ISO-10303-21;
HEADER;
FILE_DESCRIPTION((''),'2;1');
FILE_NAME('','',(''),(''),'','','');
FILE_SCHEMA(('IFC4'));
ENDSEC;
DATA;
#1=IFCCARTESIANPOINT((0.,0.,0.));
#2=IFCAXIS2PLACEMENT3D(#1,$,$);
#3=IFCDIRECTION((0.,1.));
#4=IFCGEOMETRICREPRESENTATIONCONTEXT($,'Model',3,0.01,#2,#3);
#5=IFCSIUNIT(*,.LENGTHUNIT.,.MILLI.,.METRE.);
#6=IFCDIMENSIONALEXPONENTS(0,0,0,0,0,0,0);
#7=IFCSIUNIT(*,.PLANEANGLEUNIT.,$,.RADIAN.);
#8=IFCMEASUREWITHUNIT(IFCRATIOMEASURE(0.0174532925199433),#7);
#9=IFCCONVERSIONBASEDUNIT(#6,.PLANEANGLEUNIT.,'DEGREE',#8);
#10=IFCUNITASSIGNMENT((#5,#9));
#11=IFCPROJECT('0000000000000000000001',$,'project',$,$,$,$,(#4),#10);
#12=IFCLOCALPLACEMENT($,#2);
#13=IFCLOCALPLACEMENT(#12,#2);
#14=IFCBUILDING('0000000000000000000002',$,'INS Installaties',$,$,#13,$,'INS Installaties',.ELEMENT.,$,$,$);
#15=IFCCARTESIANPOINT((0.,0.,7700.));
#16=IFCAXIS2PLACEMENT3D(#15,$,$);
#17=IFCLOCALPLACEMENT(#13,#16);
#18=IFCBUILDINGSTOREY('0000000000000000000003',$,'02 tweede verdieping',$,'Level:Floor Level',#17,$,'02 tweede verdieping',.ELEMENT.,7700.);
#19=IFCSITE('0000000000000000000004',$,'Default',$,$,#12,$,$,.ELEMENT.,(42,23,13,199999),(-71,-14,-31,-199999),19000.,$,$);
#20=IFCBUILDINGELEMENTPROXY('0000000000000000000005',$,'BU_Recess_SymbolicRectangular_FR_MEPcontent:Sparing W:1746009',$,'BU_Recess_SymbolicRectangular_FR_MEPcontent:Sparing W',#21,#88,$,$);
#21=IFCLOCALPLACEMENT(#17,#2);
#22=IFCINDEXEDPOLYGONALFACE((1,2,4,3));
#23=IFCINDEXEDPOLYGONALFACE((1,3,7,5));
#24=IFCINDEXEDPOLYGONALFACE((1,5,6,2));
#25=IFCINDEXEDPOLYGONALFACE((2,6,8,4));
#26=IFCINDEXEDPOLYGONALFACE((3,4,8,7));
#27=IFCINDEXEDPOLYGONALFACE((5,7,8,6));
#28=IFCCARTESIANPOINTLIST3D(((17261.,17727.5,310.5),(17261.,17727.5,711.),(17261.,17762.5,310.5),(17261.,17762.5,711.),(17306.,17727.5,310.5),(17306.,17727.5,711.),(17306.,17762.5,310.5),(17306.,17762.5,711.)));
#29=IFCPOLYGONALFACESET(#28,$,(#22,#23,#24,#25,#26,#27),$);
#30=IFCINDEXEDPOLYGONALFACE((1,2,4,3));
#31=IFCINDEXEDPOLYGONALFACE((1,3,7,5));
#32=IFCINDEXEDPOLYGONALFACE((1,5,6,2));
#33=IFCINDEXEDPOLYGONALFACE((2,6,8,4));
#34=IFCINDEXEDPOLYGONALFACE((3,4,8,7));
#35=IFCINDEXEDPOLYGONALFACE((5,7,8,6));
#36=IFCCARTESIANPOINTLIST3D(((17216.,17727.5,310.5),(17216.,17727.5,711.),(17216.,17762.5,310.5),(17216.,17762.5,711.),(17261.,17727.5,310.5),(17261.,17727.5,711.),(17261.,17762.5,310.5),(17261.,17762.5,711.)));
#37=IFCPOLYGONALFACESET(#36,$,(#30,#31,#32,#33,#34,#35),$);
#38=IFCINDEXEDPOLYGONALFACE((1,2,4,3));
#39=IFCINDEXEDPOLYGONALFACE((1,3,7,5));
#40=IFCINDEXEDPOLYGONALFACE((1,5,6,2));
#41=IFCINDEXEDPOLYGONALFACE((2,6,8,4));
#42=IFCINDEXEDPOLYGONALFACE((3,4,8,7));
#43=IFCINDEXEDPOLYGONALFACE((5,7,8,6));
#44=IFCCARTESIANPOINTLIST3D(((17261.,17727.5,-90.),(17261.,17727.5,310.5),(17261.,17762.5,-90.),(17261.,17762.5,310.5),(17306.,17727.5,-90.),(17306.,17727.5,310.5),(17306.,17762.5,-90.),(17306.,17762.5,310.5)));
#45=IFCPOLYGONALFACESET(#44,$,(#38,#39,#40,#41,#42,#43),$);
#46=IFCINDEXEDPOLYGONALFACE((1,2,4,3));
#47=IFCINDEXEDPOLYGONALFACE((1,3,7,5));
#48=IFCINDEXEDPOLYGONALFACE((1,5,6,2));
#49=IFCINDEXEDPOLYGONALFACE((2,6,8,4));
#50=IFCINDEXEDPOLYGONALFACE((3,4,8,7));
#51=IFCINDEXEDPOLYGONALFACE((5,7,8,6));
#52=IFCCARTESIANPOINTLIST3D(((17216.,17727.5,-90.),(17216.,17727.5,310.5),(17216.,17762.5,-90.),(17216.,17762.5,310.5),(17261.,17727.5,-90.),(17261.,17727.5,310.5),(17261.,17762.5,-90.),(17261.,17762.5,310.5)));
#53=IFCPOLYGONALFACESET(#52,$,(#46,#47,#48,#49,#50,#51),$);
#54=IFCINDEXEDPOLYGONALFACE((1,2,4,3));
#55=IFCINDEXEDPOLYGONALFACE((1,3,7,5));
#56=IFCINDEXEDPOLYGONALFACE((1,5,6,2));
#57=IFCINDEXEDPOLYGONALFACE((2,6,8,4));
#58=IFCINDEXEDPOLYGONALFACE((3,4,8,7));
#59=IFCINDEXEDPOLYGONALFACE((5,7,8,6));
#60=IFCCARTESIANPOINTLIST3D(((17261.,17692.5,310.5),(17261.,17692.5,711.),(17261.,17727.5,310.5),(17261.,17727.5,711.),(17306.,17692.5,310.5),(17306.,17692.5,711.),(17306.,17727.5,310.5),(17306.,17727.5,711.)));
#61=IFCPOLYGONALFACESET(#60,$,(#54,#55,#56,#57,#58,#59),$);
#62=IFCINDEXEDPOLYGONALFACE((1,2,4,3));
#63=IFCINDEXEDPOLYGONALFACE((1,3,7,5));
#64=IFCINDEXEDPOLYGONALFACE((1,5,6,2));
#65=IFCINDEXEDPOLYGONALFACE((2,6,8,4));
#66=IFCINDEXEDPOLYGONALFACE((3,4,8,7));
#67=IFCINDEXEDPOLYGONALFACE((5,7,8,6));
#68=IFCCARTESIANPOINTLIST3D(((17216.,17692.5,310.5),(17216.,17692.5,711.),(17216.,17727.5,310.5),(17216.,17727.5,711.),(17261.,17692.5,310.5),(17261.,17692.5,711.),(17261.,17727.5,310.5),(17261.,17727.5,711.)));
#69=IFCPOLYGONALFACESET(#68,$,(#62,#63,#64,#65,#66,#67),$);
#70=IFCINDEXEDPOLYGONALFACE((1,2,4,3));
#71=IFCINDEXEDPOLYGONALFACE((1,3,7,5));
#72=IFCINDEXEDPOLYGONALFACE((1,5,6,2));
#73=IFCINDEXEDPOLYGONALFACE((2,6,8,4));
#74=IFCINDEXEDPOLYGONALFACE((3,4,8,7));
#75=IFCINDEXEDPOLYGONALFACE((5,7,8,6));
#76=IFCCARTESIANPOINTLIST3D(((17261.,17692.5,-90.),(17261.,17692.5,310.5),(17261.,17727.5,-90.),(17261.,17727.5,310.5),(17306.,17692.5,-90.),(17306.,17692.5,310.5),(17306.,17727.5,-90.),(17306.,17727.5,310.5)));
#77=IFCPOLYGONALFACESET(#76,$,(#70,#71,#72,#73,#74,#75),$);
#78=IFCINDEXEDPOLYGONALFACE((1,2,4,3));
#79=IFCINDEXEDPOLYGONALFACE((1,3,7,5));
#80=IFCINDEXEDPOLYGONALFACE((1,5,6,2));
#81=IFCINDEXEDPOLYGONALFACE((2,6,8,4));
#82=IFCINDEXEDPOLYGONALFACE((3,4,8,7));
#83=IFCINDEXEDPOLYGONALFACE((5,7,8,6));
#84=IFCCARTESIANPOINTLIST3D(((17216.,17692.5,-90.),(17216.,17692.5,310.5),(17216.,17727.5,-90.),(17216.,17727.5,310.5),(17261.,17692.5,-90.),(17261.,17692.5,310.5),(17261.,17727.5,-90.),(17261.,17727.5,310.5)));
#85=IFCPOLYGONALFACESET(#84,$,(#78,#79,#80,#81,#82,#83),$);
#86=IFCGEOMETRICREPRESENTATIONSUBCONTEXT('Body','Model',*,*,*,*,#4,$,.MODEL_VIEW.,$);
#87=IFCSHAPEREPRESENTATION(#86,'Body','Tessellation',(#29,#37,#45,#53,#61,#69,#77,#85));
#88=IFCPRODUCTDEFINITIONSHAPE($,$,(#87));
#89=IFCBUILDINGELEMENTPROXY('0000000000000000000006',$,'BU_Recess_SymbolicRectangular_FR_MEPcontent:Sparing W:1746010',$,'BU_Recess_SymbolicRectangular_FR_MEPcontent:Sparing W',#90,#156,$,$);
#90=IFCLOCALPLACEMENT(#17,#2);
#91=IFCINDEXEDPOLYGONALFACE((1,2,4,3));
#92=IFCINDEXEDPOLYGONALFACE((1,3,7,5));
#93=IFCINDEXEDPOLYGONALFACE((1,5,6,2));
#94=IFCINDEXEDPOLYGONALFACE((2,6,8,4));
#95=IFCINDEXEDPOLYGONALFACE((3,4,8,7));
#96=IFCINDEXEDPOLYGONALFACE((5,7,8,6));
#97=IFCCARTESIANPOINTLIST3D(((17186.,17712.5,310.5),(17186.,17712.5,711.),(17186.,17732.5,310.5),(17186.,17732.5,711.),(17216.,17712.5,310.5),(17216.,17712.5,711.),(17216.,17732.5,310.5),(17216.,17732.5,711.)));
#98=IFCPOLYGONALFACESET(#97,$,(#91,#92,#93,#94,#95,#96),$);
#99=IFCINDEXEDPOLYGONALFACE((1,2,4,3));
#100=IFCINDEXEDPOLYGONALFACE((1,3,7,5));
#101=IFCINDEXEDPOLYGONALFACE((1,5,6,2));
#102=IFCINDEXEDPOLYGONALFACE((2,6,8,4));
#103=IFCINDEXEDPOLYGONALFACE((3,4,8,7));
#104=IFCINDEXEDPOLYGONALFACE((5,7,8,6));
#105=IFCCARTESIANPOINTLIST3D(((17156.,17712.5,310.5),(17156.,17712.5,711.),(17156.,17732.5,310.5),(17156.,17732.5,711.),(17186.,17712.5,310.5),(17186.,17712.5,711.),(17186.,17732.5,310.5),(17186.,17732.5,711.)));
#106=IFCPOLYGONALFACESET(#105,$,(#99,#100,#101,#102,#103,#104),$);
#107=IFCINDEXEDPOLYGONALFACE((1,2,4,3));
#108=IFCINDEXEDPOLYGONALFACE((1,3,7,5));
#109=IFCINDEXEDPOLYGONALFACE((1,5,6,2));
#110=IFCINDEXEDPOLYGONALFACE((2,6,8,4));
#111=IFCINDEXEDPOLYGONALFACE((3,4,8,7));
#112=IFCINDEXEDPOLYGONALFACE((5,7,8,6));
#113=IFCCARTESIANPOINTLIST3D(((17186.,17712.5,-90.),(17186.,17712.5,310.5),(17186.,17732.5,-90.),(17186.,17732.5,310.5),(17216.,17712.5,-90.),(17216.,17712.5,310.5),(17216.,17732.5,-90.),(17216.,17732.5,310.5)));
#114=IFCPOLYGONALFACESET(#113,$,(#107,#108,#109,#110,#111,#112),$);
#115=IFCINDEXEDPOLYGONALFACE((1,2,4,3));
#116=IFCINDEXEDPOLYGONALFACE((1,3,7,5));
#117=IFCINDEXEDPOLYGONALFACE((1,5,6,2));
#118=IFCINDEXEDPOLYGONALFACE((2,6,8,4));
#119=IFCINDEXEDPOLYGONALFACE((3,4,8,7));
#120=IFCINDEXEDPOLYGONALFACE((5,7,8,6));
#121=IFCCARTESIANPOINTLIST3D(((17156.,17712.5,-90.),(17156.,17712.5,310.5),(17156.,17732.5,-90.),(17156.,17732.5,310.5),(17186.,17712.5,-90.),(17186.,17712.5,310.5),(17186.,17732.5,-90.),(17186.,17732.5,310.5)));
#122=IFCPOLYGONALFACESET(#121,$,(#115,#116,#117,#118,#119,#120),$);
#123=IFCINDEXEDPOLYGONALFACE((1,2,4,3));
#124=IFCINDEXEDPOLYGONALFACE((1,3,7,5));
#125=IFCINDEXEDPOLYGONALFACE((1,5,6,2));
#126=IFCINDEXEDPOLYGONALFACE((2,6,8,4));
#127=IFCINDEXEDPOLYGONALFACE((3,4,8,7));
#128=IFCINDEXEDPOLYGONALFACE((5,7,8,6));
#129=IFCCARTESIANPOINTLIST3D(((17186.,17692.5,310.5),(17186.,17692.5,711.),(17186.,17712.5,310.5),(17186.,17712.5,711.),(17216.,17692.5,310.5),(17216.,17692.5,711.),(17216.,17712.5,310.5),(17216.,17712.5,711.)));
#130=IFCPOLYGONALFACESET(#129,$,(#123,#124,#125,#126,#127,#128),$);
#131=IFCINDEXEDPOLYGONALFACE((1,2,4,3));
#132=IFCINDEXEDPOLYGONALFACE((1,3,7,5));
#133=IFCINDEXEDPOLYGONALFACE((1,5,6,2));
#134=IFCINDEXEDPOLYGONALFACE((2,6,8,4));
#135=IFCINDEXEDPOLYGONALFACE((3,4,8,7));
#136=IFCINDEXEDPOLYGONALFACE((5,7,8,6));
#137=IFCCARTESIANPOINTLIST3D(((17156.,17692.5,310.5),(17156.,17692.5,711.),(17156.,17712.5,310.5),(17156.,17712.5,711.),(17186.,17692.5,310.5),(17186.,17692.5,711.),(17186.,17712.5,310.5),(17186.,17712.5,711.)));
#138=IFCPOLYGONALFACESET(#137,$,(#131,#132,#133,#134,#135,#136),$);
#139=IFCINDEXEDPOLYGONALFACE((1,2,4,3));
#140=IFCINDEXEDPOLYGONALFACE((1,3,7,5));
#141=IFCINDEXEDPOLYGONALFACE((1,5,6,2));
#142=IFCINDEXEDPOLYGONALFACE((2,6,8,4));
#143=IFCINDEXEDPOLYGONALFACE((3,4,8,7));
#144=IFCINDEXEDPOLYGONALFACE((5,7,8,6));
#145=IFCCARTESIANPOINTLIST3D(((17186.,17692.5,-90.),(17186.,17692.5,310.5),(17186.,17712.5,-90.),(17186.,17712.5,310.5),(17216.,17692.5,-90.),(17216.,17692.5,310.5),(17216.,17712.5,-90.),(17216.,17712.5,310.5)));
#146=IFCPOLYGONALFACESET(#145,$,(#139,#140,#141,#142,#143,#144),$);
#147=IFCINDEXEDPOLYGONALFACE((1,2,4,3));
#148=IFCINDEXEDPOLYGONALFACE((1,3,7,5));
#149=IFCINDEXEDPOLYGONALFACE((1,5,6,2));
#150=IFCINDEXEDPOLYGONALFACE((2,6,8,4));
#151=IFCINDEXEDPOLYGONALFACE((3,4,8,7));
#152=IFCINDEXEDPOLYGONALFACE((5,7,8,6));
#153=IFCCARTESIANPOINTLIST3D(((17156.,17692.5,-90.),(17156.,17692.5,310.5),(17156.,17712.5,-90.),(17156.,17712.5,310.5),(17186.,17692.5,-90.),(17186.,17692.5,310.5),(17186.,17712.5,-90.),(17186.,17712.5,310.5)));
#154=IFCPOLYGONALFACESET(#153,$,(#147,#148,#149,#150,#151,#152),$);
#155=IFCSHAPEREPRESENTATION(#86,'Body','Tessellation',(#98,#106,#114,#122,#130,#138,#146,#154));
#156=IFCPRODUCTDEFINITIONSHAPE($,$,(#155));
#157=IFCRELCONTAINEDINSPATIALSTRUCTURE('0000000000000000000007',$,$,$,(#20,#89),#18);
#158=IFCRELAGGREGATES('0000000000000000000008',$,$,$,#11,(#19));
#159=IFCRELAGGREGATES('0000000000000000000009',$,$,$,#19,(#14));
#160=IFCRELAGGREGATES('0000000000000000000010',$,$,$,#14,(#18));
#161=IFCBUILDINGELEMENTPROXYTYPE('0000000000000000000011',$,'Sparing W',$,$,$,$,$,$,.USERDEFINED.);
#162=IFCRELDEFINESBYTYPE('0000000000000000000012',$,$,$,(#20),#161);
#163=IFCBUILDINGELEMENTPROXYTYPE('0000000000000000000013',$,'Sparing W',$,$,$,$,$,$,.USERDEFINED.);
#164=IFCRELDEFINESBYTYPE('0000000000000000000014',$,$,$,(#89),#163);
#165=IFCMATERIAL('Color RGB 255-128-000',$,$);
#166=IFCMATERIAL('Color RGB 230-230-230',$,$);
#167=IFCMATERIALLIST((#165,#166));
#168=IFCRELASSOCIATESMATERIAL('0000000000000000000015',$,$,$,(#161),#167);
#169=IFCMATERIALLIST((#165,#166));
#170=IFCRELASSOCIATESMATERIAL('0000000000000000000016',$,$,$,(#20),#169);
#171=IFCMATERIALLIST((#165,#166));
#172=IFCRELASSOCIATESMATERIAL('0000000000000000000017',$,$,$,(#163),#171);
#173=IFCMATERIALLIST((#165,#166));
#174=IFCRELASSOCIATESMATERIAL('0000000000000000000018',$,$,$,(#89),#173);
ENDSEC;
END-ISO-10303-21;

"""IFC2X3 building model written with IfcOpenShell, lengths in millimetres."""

from ifc_helpers import new_model, entity, si_unit, converted_unit, direction, frame, frame_2d, origin, origin_2d_with_axis, place, context, subcontext, project, spatial, rectangle, extrude, source, transform, mapped, material, material_list, type_object, type_shapes, element, save


model = new_model("IFC2X3")

# Units and contexts
model_context = context("Model", 3, precision=0.01, world=origin(), true_north=direction((0.0, 1.0)))
body_context = subcontext(model_context, "Body", "Model", "MODEL_VIEW")
ifc_project = project(units=[si_unit("LENGTHUNIT", "METRE", prefix="MILLI"), converted_unit("PLANEANGLEUNIT", "DEGREE", entity("IfcRatioMeasure", 0.0174532925199433), si_unit("PLANEANGLEUNIT", "RADIAN"), dimensions=[0, 0, 0, 0, 0, 0, 0])], contexts=[model_context])

# Site, building, storey
site_placement = place(None, origin())
site = spatial("IfcSite", under=ifc_project, at=site_placement, Name="Default", CompositionType="ELEMENT", RefLatitude=(42, 23, 13, 199999), RefLongitude=(-71, -14, -31, -199999), RefElevation=19000.0)
building_placement = place(site_placement, origin())
building = spatial("IfcBuilding", under=site, at=building_placement, Name="INS Installaties", LongName="INS Installaties", CompositionType="ELEMENT")
storey_placement = place(building_placement, frame((0.0, 0.0, 7700.0)))
storey = spatial("IfcBuildingStorey", under=building, at=storey_placement, Name="02 tweede verdieping", ObjectType="Level:Floor Level", LongName="02 tweede verdieping", CompositionType="ELEMENT", Elevation=7700.0)

# Building element proxies
ifc_material_1 = material(Name="Color RGB 255-128-000")
ifc_material_2 = material(Name="Color RGB 230-230-230")
ifc_material_list_1 = material_list([ifc_material_1, ifc_material_2])
ifc_material_list_2 = material_list([ifc_material_1, ifc_material_2])
building_element_proxy_type_1 = type_object("IfcBuildingElementProxyType", Name="Sparing W", PredefinedType="USERDEFINED", material=ifc_material_list_2)
shared_shape_1 = source(origin(), body_context, "Body", "SweptSolid", [
    extrude(rectangle(XDim=45.0, YDim=35.0, at=frame_2d((0.0, 0.0), x_axis=(1.0, 0.0))), frame((22.5, 49.5, 0.0)), (0.0, 0.0, 1.0), 400.5),
    extrude(rectangle(XDim=45.0, YDim=35.0, at=frame_2d((0.0, 0.0), x_axis=(1.0, 0.0))), frame((-22.5, 49.5, 0.0)), (0.0, 0.0, 1.0), 400.5),
    extrude(rectangle(XDim=45.0, YDim=35.0, at=frame_2d((0.0, 0.0), x_axis=(1.0, 0.0))), frame((22.5, 49.5, -400.5)), (0.0, 0.0, 1.0), 400.5),
    extrude(rectangle(XDim=45.0, YDim=35.0, at=frame_2d((0.0, 0.0), x_axis=(1.0, 0.0))), frame((-22.5, 49.5, -400.5)), (0.0, 0.0, 1.0), 400.5),
    extrude(rectangle(XDim=45.0, YDim=35.0, at=origin_2d_with_axis()), frame((22.5, 14.5, 0.0)), (0.0, 0.0, 1.0), 400.5),
    extrude(rectangle(XDim=45.0, YDim=35.0, at=frame_2d((0.0, 0.0), x_axis=(1.0, 0.0))), frame((-22.5, 14.5, 0.0)), (0.0, 0.0, 1.0), 400.5),
    extrude(rectangle(XDim=45.0, YDim=35.0, at=frame_2d((0.0, 0.0), x_axis=(1.0, 0.0))), frame((22.5, 14.5, -400.5)), (0.0, 0.0, 1.0), 400.5),
    extrude(rectangle(XDim=45.0, YDim=35.0, at=origin_2d_with_axis()), frame((-22.5, 14.5, -400.5)), (0.0, 0.0, 1.0), 400.5),
])
type_shapes(building_element_proxy_type_1, [shared_shape_1])
proxy_1_placement = place(storey_placement, frame((17261.0, 17695.5, 310.5)))
element("IfcBuildingElementProxy", 1, at=proxy_1_placement, inside=storey, type_object=building_element_proxy_type_1, material=ifc_material_list_1, Name="BU_Recess_SymbolicRectangular_FR_MEPcontent:Sparing W:1746009", ObjectType="BU_Recess_SymbolicRectangular_FR_MEPcontent:Sparing W", context=body_context, shape_type="MappedRepresentation", body=[
    mapped(shared_shape_1, transform((0.0, 0.0, 0.0), scale=1.0)),
])
ifc_material_list_3 = material_list([ifc_material_1, ifc_material_2])
ifc_material_list_4 = material_list([ifc_material_1, ifc_material_2])
building_element_proxy_type_2 = type_object("IfcBuildingElementProxyType", Name="Sparing W", PredefinedType="USERDEFINED", material=ifc_material_list_4)
shared_shape_2 = source(origin(), body_context, "Body", "SweptSolid", [
    extrude(rectangle(XDim=30.0, YDim=20.0, at=frame_2d((0.0, 0.0), x_axis=(1.0, 0.0))), frame((15.0, 27.0, 0.0)), (0.0, 0.0, 1.0), 400.5),
    extrude(rectangle(XDim=30.0, YDim=20.0, at=frame_2d((0.0, 0.0), x_axis=(1.0, 0.0))), frame((-15.0, 27.0, 0.0)), (0.0, 0.0, 1.0), 400.5),
    extrude(rectangle(XDim=30.0, YDim=20.0, at=frame_2d((0.0, 0.0), x_axis=(1.0, 0.0))), frame((15.0, 27.0, -400.5)), (0.0, 0.0, 1.0), 400.5),
    extrude(rectangle(XDim=30.0, YDim=20.0, at=origin_2d_with_axis()), frame((-15.0, 27.0, -400.5)), (0.0, 0.0, 1.0), 400.5),
    extrude(rectangle(XDim=30.0, YDim=20.0, at=frame_2d((0.0, 0.0), x_axis=(1.0, 0.0))), frame((15.0, 7.0, 0.0)), (0.0, 0.0, 1.0), 400.5),
    extrude(rectangle(XDim=30.0, YDim=20.0, at=origin_2d_with_axis()), frame((-15.0, 7.0, 0.0)), (0.0, 0.0, 1.0), 400.5),
    extrude(rectangle(XDim=30.0, YDim=20.0, at=frame_2d((0.0, 0.0), x_axis=(1.0, 0.0))), frame((15.0, 7.0, -400.5)), (0.0, 0.0, 1.0), 400.5),
    extrude(rectangle(XDim=30.0, YDim=20.0, at=origin_2d_with_axis()), frame((-15.0, 7.0, -400.5)), (0.0, 0.0, 1.0), 400.5),
])
type_shapes(building_element_proxy_type_2, [shared_shape_2])
proxy_2_placement = place(storey_placement, frame((17186.0, 17695.5, 310.5)))
element("IfcBuildingElementProxy", 2, at=proxy_2_placement, inside=storey, type_object=building_element_proxy_type_2, material=ifc_material_list_3, Name="BU_Recess_SymbolicRectangular_FR_MEPcontent:Sparing W:1746010", ObjectType="BU_Recess_SymbolicRectangular_FR_MEPcontent:Sparing W", context=body_context, shape_type="MappedRepresentation", body=[
    mapped(shared_shape_2, transform((0.0, 0.0, 0.0), scale=1.0)),
])

save(model, "model.ifc")
